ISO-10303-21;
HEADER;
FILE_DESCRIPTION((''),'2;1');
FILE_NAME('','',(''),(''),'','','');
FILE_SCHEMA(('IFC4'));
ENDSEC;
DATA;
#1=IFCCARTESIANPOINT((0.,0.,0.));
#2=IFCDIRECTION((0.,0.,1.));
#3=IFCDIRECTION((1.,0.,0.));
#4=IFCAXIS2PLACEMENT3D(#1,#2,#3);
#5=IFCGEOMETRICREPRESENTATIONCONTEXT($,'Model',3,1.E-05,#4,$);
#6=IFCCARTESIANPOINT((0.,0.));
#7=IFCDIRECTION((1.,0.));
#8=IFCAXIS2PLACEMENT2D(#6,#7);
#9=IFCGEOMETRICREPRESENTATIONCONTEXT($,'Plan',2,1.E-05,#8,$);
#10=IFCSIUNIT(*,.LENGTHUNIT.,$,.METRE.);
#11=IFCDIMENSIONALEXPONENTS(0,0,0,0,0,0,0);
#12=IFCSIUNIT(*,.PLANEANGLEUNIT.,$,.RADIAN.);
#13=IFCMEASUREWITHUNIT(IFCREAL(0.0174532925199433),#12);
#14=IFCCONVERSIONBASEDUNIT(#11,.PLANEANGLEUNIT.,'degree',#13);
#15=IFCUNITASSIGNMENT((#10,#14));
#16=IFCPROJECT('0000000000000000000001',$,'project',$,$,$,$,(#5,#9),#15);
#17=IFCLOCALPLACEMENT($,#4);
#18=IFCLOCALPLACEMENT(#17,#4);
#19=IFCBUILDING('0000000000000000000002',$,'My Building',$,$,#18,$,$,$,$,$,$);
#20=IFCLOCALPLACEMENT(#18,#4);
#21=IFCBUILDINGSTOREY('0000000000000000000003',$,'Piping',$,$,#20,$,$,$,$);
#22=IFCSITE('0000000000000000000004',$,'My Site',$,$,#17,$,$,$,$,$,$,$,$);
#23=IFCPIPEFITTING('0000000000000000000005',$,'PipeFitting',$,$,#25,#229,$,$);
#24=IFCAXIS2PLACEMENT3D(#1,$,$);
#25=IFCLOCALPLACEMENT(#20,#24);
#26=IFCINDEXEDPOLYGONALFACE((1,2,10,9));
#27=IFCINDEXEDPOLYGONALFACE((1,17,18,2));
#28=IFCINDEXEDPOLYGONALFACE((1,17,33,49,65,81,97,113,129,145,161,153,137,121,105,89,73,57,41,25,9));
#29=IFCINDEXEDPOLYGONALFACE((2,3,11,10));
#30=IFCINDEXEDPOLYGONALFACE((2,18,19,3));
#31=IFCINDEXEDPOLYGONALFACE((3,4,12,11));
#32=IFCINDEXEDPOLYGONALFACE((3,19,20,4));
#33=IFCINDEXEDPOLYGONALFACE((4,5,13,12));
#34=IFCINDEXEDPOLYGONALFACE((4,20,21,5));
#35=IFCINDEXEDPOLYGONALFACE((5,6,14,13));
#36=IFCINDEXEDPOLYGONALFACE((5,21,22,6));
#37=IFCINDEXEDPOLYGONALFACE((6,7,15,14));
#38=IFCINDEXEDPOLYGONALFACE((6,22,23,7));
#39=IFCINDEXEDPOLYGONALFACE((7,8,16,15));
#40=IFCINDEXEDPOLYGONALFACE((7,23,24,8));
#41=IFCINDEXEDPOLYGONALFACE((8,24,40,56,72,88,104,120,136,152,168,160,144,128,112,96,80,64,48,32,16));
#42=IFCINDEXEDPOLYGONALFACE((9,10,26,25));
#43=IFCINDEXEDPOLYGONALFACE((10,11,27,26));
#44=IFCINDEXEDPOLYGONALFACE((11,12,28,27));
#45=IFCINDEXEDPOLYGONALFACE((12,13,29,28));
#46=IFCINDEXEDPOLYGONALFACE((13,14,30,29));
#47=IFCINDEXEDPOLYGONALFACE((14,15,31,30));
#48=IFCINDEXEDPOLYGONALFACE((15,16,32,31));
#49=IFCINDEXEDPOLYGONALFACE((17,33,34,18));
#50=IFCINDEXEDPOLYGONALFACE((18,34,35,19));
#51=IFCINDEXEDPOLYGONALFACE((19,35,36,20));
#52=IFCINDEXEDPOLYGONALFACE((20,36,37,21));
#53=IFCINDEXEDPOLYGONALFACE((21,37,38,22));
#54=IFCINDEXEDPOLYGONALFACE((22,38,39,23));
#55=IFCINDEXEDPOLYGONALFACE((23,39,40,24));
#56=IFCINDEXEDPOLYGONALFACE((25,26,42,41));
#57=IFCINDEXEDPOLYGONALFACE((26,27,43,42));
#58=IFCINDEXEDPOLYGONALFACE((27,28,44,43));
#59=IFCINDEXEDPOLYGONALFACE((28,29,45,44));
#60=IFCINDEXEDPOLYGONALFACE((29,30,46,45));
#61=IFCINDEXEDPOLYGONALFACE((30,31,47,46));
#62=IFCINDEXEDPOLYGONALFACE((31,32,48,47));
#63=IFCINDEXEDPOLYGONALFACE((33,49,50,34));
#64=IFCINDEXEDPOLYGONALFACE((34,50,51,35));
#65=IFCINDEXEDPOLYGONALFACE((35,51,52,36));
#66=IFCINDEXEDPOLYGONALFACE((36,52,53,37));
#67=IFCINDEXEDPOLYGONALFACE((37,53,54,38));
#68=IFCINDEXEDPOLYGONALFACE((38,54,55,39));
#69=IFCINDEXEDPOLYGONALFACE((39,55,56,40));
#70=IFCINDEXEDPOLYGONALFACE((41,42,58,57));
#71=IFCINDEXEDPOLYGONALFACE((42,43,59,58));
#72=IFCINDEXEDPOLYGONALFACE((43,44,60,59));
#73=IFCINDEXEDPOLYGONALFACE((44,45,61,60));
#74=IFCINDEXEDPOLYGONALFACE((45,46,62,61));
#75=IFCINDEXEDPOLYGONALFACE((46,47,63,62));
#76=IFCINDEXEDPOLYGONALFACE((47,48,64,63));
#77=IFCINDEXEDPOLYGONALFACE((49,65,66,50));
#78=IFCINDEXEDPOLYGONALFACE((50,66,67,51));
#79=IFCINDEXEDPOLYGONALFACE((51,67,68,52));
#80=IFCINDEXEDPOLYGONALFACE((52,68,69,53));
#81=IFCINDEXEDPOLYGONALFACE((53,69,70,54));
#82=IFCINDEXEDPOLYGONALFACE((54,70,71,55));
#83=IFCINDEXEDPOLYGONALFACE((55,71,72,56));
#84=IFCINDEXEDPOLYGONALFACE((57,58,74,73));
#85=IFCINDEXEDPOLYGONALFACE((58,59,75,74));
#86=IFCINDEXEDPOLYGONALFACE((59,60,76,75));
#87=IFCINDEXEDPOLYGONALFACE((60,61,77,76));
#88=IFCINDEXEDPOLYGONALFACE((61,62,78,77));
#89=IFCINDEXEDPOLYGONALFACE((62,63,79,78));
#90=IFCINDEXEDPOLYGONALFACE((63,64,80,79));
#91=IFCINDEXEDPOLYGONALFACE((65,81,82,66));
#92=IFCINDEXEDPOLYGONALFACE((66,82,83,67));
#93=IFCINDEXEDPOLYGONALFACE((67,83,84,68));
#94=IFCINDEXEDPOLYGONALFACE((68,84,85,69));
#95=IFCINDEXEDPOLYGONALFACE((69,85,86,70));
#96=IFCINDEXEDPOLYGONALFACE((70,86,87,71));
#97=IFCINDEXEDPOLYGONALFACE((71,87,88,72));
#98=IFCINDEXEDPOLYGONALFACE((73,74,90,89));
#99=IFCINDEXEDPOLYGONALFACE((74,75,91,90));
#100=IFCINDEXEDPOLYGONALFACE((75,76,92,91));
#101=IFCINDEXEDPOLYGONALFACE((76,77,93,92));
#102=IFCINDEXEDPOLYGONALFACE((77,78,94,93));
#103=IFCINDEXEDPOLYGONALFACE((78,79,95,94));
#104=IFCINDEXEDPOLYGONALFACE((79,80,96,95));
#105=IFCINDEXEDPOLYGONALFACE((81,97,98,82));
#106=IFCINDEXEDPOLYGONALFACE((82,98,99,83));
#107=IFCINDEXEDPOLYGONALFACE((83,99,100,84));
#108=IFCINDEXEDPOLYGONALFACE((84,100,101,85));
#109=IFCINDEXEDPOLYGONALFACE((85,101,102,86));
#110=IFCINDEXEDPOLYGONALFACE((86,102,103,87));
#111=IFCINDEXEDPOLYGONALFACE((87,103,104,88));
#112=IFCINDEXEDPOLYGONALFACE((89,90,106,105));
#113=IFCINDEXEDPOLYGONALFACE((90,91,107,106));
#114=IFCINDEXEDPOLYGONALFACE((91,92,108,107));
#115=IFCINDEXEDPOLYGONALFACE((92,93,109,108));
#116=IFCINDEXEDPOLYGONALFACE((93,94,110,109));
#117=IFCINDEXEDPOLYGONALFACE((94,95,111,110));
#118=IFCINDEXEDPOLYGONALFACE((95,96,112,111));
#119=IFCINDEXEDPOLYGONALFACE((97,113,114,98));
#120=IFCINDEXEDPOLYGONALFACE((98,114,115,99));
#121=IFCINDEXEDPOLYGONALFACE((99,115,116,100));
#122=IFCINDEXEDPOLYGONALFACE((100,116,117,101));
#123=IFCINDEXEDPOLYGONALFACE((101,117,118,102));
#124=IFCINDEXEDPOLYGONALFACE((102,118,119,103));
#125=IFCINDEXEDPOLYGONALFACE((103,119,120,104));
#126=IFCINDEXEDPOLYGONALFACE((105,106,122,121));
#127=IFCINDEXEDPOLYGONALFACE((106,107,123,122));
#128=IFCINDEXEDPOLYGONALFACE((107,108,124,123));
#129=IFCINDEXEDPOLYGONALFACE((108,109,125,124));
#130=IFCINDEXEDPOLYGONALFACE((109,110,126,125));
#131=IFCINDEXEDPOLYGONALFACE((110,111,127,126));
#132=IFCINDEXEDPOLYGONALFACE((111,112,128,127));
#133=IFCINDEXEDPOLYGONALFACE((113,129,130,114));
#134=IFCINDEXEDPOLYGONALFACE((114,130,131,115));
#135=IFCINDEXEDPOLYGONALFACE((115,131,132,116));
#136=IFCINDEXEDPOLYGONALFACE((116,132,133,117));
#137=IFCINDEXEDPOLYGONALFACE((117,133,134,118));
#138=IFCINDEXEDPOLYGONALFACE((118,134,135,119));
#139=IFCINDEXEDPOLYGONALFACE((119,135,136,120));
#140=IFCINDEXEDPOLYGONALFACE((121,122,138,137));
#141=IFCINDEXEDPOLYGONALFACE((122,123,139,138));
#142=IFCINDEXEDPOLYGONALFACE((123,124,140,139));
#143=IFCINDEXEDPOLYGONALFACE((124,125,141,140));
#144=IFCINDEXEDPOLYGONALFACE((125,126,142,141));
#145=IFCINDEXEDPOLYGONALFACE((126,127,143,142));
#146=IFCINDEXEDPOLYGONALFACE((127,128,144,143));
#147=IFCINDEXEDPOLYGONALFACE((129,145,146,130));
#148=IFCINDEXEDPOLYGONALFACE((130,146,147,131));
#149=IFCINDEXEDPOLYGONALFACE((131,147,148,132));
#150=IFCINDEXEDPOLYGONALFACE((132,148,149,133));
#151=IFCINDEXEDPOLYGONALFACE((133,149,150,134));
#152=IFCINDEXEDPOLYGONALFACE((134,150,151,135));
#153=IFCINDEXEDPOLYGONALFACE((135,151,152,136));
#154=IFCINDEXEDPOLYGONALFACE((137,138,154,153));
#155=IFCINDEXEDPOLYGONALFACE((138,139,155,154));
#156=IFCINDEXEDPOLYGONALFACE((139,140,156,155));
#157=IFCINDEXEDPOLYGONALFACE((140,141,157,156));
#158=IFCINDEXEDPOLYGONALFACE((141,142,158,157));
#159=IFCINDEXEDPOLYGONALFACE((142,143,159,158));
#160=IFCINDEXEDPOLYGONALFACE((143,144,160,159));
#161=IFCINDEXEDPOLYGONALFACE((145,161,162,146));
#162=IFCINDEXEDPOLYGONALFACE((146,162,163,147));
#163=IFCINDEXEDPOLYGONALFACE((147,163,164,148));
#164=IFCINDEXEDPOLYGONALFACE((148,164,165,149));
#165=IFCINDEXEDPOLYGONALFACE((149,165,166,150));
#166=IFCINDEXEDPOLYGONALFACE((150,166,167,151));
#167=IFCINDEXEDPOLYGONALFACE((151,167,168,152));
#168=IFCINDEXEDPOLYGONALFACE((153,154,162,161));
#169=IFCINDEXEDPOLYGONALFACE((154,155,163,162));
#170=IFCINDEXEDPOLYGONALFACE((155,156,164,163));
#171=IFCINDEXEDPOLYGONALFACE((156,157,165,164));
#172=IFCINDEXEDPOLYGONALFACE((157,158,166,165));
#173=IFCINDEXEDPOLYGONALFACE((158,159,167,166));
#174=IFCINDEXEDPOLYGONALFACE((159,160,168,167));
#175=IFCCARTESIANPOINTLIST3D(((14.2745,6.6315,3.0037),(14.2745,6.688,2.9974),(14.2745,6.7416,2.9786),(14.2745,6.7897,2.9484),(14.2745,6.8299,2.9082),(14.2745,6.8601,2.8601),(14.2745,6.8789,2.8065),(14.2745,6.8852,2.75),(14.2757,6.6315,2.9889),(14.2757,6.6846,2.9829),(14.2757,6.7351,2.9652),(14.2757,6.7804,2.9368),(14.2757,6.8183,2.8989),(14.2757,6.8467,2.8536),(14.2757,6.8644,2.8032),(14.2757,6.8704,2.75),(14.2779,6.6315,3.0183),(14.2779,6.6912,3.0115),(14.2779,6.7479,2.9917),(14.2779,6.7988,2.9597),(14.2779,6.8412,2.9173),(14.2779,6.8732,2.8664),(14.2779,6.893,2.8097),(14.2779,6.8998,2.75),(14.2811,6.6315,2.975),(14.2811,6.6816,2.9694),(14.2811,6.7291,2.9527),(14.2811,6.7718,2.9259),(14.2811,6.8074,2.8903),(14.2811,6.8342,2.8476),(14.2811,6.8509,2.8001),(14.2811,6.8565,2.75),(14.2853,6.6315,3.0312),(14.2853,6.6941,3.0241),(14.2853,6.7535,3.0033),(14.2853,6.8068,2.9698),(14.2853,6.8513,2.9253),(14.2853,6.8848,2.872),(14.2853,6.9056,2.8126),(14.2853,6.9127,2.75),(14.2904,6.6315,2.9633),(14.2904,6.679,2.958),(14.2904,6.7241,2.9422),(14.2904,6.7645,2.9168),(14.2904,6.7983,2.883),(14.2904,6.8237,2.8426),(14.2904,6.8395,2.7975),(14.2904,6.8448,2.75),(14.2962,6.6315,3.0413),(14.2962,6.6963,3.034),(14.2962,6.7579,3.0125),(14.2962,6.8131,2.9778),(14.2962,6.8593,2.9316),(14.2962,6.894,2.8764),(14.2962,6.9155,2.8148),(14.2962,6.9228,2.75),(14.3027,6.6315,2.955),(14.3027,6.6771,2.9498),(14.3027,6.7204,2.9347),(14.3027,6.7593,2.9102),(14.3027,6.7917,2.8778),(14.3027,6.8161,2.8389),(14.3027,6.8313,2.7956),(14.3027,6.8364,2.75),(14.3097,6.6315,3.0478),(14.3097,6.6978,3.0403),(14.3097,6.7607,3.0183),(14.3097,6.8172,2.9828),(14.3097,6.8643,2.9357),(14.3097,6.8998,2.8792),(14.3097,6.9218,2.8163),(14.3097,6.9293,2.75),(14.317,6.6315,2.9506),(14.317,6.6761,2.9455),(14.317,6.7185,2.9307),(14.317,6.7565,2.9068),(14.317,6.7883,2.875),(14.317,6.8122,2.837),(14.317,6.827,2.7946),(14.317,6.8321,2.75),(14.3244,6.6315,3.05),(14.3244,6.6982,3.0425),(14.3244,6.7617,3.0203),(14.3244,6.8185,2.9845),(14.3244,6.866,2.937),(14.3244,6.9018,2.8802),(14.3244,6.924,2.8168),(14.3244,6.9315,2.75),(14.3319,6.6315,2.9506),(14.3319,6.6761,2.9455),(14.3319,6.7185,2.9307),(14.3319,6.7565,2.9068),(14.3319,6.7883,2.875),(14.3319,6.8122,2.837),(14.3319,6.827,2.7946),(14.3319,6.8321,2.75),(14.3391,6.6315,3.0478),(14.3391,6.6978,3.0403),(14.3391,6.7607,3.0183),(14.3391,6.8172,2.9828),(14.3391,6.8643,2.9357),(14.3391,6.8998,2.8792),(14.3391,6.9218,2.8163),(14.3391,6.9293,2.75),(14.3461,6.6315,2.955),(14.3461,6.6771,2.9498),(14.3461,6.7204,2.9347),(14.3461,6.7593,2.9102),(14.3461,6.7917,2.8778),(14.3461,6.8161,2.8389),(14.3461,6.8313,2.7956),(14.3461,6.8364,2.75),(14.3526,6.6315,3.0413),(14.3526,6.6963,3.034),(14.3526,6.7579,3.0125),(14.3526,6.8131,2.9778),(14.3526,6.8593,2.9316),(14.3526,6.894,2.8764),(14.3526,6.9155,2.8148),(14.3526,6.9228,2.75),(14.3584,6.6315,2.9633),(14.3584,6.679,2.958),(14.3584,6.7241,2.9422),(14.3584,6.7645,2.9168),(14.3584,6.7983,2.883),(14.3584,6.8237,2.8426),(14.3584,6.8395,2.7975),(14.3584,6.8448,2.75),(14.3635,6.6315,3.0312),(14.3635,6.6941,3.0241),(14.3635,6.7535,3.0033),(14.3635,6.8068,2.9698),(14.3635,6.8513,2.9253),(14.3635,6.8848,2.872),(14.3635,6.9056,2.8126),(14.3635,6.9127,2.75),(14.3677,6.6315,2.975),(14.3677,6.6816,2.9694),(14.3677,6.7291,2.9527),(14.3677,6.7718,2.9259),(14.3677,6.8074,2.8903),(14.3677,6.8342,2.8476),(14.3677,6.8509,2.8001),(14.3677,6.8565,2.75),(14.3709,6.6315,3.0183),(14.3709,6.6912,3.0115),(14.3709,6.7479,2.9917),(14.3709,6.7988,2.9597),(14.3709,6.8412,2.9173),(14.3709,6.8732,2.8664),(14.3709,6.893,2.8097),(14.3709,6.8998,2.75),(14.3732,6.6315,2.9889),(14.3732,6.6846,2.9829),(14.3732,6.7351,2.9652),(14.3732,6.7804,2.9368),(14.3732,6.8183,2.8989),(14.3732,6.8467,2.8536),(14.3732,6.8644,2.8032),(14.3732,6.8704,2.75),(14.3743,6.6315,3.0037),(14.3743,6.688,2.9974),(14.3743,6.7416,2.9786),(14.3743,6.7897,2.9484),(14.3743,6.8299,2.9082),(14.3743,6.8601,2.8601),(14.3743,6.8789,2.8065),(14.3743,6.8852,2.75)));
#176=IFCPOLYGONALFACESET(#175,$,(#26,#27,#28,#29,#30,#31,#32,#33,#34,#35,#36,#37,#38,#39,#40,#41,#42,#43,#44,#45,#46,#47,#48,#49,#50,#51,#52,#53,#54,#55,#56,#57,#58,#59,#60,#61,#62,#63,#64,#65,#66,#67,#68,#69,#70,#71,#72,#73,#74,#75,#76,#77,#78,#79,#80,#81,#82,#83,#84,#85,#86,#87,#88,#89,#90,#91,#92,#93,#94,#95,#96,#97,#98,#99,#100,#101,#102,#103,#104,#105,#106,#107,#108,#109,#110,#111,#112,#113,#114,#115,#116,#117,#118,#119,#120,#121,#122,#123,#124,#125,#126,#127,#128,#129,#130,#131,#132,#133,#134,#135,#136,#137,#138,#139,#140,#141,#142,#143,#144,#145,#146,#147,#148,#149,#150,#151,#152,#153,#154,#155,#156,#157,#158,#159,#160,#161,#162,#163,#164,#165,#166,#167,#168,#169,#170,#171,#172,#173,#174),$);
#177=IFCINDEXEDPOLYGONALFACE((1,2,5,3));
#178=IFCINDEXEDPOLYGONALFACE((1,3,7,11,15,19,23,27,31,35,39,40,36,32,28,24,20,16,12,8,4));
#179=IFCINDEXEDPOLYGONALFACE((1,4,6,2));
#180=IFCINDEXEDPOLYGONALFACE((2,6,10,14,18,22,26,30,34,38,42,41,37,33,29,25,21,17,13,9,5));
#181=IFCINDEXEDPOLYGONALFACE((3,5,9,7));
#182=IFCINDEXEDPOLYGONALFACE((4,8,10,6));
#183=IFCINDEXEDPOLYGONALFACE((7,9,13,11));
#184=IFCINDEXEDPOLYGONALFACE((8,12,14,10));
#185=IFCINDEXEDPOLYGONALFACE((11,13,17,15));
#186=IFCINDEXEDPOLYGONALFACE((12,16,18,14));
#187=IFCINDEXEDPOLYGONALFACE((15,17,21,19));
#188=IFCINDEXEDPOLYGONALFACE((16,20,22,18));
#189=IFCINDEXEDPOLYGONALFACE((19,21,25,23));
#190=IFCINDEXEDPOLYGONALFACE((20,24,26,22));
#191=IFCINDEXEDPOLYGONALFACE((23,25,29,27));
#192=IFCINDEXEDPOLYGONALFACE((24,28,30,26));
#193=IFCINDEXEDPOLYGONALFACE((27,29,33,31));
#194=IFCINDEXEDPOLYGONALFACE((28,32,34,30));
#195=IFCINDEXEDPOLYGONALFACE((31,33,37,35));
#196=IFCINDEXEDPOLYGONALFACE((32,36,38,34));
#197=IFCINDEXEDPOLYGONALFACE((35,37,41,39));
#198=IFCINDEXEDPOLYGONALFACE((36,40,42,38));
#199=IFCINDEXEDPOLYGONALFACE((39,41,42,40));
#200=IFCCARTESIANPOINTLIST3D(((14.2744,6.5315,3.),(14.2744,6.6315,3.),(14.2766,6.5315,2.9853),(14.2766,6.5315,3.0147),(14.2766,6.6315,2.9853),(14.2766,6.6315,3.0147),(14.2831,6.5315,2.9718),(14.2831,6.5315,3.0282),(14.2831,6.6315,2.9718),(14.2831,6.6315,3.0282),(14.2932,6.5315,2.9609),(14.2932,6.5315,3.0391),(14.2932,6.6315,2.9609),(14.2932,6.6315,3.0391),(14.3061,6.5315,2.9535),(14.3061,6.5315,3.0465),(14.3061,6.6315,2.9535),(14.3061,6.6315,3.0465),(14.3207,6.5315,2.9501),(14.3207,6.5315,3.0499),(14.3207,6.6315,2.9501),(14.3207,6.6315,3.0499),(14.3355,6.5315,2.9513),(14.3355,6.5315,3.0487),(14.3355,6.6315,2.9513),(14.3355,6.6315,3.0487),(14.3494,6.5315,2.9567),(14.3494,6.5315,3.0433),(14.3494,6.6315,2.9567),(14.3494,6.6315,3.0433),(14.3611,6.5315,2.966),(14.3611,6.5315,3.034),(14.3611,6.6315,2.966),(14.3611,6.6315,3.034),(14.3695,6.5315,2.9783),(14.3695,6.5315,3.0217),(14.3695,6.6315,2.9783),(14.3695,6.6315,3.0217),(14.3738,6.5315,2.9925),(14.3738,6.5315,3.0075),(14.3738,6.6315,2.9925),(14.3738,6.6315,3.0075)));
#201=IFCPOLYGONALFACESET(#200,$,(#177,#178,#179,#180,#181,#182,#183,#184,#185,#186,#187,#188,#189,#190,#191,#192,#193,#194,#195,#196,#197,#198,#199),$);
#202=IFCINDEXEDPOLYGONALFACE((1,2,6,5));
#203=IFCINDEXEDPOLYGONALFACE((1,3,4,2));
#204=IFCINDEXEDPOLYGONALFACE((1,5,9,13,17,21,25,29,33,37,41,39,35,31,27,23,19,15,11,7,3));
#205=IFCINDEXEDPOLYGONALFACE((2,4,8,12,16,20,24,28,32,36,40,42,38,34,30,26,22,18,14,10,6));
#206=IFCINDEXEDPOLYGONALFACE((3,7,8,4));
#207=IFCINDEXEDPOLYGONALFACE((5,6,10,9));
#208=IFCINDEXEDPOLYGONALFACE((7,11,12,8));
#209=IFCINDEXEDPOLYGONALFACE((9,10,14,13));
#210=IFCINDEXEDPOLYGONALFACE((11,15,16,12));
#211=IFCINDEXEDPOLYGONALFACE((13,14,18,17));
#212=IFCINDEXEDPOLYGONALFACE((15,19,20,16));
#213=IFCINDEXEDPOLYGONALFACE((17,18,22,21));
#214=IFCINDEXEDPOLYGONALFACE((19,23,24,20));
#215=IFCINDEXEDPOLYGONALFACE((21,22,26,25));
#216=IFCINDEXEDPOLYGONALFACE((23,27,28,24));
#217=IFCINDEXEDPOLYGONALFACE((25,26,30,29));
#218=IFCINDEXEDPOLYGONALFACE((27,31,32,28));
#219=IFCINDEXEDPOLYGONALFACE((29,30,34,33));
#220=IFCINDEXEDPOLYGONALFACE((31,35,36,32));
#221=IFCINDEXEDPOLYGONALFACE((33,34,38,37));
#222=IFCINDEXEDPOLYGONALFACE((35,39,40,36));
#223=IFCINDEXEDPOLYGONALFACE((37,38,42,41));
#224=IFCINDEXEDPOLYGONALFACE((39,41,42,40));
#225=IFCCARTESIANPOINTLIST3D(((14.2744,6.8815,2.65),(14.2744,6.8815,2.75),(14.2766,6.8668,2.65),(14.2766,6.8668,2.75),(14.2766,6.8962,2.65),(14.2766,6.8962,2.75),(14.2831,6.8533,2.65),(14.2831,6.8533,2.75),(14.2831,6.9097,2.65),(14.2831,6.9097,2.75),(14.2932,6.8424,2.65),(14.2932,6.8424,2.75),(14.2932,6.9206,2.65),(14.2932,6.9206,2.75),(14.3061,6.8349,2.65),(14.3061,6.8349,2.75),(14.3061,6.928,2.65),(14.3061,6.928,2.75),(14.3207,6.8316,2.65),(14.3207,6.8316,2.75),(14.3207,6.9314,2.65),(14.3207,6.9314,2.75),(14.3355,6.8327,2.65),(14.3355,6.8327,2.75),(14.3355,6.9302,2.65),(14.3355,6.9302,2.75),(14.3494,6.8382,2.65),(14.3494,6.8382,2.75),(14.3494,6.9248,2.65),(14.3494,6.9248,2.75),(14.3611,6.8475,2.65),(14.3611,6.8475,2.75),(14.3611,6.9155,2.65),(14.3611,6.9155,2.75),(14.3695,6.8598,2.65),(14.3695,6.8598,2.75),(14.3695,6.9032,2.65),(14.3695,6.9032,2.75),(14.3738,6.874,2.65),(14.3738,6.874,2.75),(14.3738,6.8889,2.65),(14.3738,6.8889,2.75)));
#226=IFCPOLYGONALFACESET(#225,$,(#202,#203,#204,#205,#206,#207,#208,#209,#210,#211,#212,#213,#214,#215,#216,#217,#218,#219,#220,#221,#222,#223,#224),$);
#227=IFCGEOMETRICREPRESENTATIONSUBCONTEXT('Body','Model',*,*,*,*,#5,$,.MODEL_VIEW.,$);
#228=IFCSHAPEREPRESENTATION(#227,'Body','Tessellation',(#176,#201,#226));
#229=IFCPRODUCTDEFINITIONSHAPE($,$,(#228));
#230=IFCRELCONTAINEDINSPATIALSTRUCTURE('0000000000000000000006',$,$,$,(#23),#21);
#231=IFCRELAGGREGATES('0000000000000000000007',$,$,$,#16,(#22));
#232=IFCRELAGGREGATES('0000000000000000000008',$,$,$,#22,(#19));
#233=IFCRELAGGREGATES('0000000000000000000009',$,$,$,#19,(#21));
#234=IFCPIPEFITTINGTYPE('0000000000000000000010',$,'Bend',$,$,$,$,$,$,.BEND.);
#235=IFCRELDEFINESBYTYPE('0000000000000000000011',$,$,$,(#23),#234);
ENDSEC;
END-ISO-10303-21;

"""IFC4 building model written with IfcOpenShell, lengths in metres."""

from ifc_helpers import new_model, entity, si_unit, converted_unit, frame, origin_with_axes, origin_2d_with_axis, place, context, subcontext, project, spatial, circle, extrude, source, transform, mapped, type_object, type_shapes, element, save


model = new_model("IFC4")

# Units and contexts
model_context = context("Model", 3, precision=1e-05, world=origin_with_axes())
plan_context = context("Plan", 2, precision=1e-05, world=origin_2d_with_axis())
body_context = subcontext(model_context, "Body", "Model", "MODEL_VIEW")
ifc_project = project(units=[si_unit("LENGTHUNIT", "METRE"), converted_unit("PLANEANGLEUNIT", "degree", entity("IfcReal", 0.0174532925199433), si_unit("PLANEANGLEUNIT", "RADIAN"), dimensions=[0, 0, 0, 0, 0, 0, 0])], contexts=[model_context, plan_context])

# Site, building, storey
site_placement = place(None, origin_with_axes())
site = spatial("IfcSite", under=ifc_project, at=site_placement, Name="My Site")
building_placement = place(site_placement, origin_with_axes())
building = spatial("IfcBuilding", under=site, at=building_placement, Name="My Building")
storey_placement = place(building_placement, origin_with_axes())
storey = spatial("IfcBuildingStorey", under=building, at=storey_placement, Name="Piping")

# Pipe fitting
pipe_fitting_type_1 = type_object("IfcPipeFittingType", Name="Bend", PredefinedType="BEND")
shared_shape = source(origin_with_axes(), body_context, "Body", "SolidModel", [
    entity("IfcSweptDiskSolid", entity("IfcIndexedPolyCurve", entity("IfcCartesianPointList3D", [[0.0, 0.0, -0.1], [0.0, 0.0732, -0.2768], [0.0, 0.25, -0.35]]), [entity("IfcArcIndex", [1, 2, 3])]), 0.05),
    extrude(circle(Radius=0.05), origin_with_axes(), (0.0, 0.0, -1.0), 0.1),
    extrude(circle(Radius=0.05), frame((0.0, 0.25, -0.35), z_axis=(0.0, 1.0, 0.0), x_axis=(1.0, 0.0, 0.0)), (0.0, 0.0, 1.0), 0.1),
])
type_shapes(pipe_fitting_type_1, [shared_shape])
for number, where, z_axis, x_axis, name in (
    (1, (14.3244, 6.5315, 3.0), (0.0, -1.0, 0.0), (-1.0, 0.0, 0.0), "PipeFitting"),
):
    element("IfcPipeFitting", number, at=place(storey_placement, frame(where, z_axis=z_axis, x_axis=x_axis)), inside=storey, type_object=pipe_fitting_type_1, Name=name, context=body_context, shape_type="MappedRepresentation", body=[
        mapped(shared_shape, transform((0.0, 0.0, 0.0), x_axis=(1.0, 0.0, 0.0), y_axis=(0.0, 1.0, 0.0), z_axis=(0.0, 0.0, 1.0), scale=1.0)),
    ])

save(model, "model.ifc")
